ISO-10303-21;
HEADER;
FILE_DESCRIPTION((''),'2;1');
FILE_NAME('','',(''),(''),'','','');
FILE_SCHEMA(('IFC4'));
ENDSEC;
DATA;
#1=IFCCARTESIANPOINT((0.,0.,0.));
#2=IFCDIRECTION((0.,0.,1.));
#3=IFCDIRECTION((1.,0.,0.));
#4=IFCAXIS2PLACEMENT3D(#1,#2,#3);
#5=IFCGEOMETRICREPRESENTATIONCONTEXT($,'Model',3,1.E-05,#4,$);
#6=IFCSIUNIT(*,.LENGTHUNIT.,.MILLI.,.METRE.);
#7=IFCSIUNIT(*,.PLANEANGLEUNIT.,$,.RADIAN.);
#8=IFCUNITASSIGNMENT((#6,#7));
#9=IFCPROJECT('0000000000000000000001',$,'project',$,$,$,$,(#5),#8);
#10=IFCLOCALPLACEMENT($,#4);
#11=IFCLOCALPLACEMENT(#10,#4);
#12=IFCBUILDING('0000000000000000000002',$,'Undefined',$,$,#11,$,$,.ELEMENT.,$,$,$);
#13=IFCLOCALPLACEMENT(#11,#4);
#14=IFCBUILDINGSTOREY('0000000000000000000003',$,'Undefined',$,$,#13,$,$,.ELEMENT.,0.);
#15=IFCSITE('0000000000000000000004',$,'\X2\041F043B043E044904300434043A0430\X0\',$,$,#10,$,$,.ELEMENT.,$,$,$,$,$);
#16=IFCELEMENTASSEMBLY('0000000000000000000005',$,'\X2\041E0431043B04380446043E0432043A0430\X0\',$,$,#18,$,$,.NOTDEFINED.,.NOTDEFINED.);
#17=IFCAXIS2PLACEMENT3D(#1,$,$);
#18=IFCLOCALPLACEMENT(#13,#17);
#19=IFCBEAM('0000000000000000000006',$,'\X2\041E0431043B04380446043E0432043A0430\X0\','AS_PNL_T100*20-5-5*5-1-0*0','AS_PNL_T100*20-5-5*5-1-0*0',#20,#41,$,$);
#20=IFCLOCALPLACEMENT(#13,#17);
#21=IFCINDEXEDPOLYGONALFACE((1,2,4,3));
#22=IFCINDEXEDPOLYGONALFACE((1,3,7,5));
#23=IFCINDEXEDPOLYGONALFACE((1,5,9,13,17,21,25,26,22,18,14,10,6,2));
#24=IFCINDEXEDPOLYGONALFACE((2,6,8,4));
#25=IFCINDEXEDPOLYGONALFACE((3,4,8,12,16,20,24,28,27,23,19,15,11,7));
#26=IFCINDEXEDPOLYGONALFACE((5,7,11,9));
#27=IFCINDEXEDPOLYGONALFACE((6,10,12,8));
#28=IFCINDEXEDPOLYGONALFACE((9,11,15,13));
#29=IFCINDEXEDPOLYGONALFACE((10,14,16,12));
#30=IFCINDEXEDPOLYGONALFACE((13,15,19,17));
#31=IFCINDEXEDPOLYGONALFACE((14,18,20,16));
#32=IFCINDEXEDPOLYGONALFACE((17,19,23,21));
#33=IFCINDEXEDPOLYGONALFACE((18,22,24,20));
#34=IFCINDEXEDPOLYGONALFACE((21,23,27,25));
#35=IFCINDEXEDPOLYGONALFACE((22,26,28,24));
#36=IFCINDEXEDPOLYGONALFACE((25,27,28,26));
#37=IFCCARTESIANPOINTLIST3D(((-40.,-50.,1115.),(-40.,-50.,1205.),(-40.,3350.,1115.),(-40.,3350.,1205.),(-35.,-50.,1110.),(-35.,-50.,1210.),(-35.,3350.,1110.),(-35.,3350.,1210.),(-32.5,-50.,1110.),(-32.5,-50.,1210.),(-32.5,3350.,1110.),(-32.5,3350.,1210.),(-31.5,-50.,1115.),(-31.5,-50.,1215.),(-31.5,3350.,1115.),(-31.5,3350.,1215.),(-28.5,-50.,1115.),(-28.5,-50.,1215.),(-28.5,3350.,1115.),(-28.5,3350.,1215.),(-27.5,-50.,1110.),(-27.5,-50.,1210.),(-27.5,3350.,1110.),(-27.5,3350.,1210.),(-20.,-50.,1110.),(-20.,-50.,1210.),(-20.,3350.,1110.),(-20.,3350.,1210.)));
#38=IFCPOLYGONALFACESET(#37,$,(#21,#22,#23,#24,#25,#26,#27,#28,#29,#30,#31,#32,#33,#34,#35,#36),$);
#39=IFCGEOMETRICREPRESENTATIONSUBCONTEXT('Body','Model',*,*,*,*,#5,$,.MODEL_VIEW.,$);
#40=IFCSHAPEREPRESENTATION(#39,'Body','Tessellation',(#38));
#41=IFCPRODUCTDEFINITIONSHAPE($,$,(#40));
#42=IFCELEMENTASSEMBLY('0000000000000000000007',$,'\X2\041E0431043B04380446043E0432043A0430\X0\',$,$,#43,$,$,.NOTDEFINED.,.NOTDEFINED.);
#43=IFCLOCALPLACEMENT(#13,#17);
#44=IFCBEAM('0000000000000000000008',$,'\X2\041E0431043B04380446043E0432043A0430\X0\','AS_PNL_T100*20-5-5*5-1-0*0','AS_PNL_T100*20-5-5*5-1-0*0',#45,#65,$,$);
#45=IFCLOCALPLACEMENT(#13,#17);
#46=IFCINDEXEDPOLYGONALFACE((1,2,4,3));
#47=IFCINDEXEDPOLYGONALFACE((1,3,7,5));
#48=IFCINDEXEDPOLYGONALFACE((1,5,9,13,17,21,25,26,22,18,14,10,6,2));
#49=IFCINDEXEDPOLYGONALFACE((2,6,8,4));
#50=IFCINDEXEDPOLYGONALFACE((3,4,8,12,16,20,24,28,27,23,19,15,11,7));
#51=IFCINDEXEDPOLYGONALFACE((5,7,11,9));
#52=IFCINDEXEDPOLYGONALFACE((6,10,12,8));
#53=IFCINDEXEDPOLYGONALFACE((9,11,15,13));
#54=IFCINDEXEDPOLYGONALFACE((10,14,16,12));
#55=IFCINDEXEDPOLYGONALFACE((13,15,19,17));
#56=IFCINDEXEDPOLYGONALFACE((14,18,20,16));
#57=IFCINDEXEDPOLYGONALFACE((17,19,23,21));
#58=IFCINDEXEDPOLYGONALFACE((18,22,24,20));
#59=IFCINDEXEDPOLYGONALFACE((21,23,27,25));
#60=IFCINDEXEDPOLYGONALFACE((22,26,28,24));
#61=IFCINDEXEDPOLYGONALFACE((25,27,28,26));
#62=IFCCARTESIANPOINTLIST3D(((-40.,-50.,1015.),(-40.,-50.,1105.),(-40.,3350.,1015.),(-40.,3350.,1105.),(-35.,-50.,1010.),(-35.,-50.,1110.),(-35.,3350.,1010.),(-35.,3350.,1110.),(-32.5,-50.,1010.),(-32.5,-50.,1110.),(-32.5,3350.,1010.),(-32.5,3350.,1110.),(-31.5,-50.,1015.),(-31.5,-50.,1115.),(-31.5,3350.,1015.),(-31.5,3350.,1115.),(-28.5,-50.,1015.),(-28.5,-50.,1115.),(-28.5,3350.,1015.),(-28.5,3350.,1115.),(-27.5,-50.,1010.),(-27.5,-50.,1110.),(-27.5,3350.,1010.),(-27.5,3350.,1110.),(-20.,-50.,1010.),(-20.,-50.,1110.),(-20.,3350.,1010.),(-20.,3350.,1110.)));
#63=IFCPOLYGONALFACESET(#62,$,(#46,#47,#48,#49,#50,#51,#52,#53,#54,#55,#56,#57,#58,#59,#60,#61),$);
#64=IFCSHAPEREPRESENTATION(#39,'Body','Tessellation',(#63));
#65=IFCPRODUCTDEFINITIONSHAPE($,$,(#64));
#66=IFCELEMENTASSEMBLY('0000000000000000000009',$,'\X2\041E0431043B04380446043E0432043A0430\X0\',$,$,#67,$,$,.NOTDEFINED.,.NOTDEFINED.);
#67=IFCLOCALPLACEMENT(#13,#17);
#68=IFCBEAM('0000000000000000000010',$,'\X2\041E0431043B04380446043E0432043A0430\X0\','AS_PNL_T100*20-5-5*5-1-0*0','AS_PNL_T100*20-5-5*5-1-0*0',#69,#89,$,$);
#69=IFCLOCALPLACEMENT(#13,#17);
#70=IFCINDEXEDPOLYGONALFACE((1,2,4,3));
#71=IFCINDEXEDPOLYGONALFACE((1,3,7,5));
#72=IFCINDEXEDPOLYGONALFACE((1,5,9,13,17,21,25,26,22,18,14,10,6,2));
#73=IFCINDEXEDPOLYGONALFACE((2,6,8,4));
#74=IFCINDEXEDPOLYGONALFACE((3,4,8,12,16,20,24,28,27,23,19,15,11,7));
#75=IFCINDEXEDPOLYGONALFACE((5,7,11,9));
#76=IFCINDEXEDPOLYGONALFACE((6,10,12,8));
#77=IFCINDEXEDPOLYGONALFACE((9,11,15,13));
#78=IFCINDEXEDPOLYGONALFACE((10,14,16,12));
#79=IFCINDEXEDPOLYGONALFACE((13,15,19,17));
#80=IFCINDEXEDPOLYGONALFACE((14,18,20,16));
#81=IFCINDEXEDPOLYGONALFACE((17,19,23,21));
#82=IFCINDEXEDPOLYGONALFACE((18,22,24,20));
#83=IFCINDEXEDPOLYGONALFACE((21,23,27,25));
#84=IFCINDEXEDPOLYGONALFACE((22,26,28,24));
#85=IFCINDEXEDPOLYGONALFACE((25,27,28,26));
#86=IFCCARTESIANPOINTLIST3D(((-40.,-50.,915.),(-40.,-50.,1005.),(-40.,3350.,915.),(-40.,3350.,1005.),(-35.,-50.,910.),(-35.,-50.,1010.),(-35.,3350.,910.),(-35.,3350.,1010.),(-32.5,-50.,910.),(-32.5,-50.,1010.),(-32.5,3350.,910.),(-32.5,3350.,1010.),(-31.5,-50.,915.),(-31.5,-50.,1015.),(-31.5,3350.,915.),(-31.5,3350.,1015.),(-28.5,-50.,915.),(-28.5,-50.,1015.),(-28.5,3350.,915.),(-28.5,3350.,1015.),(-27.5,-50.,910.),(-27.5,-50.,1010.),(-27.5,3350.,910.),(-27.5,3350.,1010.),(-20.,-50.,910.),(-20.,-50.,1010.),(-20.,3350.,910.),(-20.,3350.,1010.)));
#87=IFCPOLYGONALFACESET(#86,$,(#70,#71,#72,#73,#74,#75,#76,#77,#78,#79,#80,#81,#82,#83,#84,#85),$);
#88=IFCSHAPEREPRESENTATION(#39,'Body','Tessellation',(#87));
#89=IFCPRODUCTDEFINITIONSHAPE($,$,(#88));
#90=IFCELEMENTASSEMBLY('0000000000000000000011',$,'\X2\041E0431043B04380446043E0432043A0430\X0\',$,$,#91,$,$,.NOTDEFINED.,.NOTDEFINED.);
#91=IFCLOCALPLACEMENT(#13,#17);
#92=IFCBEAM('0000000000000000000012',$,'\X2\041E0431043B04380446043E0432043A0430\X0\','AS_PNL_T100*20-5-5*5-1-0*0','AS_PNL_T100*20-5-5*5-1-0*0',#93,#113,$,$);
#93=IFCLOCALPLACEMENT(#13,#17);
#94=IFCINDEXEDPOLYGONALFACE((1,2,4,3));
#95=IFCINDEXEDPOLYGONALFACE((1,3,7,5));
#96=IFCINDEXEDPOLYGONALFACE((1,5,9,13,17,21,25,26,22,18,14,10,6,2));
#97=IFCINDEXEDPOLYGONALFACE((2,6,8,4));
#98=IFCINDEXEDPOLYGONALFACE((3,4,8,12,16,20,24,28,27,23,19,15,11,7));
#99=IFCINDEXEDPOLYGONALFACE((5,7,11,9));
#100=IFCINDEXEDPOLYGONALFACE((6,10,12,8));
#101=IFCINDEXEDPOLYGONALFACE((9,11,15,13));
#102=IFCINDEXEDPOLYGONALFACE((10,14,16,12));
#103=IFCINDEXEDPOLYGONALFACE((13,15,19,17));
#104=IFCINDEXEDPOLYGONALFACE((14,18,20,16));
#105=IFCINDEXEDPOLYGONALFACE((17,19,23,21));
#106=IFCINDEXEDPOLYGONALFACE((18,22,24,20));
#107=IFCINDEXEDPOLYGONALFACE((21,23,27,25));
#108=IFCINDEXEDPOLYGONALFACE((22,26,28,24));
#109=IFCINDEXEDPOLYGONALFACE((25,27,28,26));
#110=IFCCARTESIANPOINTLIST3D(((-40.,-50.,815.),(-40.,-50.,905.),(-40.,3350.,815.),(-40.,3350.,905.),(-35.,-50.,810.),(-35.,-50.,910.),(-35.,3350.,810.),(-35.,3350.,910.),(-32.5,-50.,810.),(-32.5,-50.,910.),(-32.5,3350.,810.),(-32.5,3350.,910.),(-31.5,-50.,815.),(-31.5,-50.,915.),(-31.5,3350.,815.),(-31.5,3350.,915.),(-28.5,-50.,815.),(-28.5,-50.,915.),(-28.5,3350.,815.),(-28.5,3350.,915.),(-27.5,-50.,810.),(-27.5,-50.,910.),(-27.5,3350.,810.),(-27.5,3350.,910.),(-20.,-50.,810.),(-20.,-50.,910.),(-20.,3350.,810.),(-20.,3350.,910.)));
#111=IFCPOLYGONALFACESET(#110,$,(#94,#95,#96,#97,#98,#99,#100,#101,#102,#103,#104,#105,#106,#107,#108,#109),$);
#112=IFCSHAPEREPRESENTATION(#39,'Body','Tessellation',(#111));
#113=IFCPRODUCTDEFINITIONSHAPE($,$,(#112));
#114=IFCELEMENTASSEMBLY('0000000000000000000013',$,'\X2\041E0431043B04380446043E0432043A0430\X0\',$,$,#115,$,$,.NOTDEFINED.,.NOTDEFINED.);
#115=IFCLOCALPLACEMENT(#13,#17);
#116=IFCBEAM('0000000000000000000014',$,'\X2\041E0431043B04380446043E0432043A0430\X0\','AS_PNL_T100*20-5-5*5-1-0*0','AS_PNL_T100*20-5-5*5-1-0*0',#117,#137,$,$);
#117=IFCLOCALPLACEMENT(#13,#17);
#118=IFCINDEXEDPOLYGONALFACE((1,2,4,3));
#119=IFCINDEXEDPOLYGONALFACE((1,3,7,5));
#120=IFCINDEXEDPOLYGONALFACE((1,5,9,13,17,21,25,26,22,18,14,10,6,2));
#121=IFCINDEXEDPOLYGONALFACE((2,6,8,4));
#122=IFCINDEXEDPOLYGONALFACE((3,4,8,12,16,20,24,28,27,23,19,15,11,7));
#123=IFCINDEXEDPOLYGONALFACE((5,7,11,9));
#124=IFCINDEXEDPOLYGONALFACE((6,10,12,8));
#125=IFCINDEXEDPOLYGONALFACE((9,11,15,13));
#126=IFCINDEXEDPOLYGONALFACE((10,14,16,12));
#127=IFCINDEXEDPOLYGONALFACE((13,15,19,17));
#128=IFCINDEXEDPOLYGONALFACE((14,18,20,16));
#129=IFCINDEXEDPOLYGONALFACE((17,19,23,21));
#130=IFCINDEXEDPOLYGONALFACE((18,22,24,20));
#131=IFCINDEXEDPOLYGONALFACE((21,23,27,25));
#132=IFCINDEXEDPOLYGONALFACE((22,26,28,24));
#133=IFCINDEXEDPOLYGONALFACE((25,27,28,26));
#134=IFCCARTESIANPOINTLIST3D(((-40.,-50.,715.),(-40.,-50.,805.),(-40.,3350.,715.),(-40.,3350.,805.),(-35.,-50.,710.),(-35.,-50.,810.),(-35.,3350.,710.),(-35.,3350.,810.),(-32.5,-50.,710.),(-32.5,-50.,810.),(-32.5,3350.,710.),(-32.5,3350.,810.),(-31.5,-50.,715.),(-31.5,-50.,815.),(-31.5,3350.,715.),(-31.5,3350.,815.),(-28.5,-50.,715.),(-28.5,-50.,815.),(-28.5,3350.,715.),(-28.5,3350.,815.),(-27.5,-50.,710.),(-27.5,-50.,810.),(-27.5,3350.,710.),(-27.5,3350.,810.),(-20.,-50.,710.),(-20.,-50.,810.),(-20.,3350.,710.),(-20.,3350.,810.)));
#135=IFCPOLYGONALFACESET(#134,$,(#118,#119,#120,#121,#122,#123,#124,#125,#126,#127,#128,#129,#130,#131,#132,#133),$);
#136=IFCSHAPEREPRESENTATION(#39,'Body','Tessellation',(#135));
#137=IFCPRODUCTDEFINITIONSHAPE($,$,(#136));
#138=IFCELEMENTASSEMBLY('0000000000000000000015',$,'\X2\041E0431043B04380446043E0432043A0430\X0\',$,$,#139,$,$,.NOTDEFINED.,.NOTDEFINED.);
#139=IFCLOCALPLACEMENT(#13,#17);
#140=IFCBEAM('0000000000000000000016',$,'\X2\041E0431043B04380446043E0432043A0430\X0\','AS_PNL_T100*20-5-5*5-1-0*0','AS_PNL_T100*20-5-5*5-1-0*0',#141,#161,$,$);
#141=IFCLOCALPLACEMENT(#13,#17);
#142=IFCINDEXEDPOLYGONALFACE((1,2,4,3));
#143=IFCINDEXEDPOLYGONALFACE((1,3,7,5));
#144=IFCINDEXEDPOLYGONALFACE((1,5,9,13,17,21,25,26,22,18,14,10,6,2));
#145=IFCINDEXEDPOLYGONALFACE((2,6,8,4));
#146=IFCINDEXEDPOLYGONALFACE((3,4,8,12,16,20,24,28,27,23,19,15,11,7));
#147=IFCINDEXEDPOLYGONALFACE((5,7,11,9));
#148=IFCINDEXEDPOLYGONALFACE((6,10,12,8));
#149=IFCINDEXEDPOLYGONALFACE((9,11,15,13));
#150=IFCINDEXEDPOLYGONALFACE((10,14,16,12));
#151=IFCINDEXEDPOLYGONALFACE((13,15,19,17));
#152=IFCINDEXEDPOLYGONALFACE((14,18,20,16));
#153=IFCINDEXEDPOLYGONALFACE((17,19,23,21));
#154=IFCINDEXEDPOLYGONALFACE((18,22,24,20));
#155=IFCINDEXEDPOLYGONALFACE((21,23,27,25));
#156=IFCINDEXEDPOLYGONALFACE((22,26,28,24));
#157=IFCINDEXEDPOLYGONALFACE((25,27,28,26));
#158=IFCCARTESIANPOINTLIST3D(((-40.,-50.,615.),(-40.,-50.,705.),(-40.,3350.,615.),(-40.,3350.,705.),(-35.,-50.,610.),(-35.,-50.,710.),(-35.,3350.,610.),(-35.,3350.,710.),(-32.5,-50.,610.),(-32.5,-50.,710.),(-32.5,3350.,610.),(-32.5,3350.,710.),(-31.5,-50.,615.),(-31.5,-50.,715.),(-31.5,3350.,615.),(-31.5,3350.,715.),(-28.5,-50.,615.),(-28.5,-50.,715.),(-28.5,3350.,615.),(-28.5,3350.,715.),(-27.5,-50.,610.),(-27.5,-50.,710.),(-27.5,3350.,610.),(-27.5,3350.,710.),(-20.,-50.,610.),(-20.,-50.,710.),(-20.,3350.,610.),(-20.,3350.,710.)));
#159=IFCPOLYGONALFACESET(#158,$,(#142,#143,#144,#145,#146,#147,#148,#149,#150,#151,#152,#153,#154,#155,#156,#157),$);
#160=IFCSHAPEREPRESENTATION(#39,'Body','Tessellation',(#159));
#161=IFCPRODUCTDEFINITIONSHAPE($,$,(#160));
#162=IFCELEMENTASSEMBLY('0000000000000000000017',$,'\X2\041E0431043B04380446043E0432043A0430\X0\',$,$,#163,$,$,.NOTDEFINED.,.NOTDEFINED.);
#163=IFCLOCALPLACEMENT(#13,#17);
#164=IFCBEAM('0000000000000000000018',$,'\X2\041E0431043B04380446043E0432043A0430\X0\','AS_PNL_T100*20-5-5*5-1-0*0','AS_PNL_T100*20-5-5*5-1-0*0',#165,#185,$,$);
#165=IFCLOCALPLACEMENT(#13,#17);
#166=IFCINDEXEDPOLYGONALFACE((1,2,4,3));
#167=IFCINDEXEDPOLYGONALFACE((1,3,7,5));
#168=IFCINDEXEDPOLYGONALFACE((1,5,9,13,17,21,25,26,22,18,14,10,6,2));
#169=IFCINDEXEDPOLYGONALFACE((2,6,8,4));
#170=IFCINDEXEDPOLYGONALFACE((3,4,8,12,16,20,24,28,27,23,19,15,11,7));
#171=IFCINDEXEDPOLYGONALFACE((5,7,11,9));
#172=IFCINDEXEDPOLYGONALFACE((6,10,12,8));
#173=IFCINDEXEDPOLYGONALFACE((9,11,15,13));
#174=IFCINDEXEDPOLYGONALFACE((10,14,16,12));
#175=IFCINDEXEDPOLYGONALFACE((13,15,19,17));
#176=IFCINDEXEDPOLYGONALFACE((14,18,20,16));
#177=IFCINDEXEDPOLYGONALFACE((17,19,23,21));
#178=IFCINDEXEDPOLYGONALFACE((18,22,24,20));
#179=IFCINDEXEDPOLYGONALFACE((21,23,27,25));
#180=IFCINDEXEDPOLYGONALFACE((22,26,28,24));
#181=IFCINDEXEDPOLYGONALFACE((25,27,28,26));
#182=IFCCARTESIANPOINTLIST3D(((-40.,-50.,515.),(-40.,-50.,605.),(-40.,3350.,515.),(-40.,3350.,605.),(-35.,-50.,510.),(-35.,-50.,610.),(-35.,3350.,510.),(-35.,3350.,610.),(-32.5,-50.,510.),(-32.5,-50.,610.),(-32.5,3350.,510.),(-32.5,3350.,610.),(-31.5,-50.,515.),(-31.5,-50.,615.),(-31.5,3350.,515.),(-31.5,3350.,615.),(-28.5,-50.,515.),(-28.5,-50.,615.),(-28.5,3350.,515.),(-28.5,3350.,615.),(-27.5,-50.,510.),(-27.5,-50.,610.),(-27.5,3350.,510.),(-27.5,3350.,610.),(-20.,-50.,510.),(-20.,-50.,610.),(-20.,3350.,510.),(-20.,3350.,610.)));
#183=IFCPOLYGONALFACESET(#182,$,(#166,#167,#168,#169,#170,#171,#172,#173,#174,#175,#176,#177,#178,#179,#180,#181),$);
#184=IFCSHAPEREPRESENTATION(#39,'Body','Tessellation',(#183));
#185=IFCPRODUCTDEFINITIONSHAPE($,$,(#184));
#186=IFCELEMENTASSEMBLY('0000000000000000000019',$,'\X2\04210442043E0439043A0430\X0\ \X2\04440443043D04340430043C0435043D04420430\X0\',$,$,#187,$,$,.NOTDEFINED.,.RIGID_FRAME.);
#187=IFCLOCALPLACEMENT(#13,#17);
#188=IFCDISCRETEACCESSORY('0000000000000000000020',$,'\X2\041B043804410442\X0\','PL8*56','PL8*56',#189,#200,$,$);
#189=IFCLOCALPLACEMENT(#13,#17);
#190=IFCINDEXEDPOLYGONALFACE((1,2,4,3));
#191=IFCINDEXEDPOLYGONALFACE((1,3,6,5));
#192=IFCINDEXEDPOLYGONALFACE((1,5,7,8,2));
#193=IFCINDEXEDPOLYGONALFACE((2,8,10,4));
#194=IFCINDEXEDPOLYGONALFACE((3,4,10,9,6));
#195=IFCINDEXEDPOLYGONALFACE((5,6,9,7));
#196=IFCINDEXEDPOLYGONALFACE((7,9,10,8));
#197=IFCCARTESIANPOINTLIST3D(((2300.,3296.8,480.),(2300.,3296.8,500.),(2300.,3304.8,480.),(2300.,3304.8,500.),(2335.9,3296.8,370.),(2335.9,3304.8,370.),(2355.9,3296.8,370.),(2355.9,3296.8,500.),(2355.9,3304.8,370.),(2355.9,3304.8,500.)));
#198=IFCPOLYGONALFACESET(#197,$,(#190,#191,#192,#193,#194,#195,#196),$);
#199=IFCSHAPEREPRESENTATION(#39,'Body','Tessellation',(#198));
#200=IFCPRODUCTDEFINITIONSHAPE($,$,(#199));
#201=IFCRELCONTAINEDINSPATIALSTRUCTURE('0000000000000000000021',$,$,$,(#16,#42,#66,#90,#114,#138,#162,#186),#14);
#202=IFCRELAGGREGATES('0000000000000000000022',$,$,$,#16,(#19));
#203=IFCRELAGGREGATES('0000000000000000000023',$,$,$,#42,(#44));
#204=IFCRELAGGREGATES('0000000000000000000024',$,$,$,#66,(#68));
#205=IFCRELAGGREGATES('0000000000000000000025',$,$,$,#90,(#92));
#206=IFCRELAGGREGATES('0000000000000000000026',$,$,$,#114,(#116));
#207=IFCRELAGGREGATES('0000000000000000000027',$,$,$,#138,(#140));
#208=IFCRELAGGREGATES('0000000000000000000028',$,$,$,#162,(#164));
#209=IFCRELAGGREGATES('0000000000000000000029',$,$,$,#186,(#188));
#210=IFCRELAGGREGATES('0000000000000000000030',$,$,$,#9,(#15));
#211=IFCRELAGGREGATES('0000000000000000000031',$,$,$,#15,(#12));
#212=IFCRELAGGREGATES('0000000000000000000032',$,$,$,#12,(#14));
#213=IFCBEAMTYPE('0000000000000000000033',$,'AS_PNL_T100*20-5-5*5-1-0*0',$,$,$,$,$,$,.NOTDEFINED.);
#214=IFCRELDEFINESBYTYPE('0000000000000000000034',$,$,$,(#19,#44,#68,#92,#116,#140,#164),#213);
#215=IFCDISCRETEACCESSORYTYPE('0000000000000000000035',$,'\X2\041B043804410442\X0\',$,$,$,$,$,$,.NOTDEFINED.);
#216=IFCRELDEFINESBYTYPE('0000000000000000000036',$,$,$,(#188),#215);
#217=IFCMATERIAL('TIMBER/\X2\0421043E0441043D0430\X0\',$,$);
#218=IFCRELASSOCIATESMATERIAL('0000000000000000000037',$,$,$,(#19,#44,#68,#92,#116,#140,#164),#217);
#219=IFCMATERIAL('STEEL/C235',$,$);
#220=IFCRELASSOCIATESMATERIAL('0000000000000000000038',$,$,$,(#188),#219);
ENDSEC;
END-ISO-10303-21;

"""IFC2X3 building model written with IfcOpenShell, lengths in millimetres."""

from ifc_helpers import new_model, si_unit, frame, origin_with_axes, place, context, subcontext, project, spatial, polyline, outline, extrude, material, type_object, element, aggregate, save


model = new_model("IFC2X3")

# Units and contexts
model_context = context("Model", 3, precision=1e-05, world=origin_with_axes())
body_context = subcontext(model_context, "Body", "Model", "MODEL_VIEW")
ifc_project = project(units=[si_unit("LENGTHUNIT", "METRE", prefix="MILLI"), si_unit("PLANEANGLEUNIT", "RADIAN")], contexts=[model_context])

# Site, building, storey
site_placement = place(None, origin_with_axes())
site = spatial("IfcSite", under=ifc_project, at=site_placement, Name="Площадка", CompositionType="ELEMENT")
building_placement = place(site_placement, origin_with_axes())
building = spatial("IfcBuilding", under=site, at=building_placement, Name="Undefined", CompositionType="ELEMENT")
storey_placement = place(building_placement, origin_with_axes())
storey = spatial("IfcBuildingStorey", under=building, at=storey_placement, Name="Undefined", CompositionType="ELEMENT", Elevation=0.0)

# Shared definitions
ifc_material_1 = material(Name="STEEL/C235")

# Element assemblies, beams
ifc_material_2 = material(Name="TIMBER/Сосна")
beam_type = type_object("IfcBeamType", Name="AS_PNL_T100*20-5-5*5-1-0*0", PredefinedType="NOTDEFINED")
assembly_1_placement = place(storey_placement, origin_with_axes())
assembly_1 = element("IfcElementAssembly", 1, at=assembly_1_placement, inside=storey, Name="Облицовка", AssemblyPlace="NOTDEFINED", PredefinedType="NOTDEFINED")
beam_1_placement = place(assembly_1_placement, frame((-30.0, 3350.0, 1160.0), z_axis=(0.0, 0.0, 1.0), x_axis=(0.0, -1.0, 0.0)))
beam_1 = element("IfcBeam", 2, at=beam_1_placement, type_object=beam_type, material=ifc_material_2, Name="Облицовка", Description="AS_PNL_T100*20-5-5*5-1-0*0", ObjectType="AS_PNL_T100*20-5-5*5-1-0*0", context=body_context, shape_type="SweptSolid", body=[
    extrude(outline(polyline([(-2.5, -50.0), (-10.0, -50.0), (-10.0, 50.0), (-2.5, 50.0), (-1.5, 55.0), (1.5, 55.0), (2.5, 50.0), (5.0, 50.0), (10.0, 45.0), (10.0, -45.0), (5.0, -50.0), (2.5, -50.0), (1.5, -45.0), (-1.5, -45.0), (-2.5, -50.0)])), frame((3400.0, 0.0, 0.0), z_axis=(-1.0, 0.0, 0.0), x_axis=(0.0, -1.0, 0.0)), (0.0, 0.0, 1.0), 3400.0),
])
aggregate(assembly_1, [beam_1])
assembly_2_placement = place(storey_placement, origin_with_axes())
assembly_2 = element("IfcElementAssembly", 3, at=assembly_2_placement, inside=storey, Name="Облицовка", AssemblyPlace="NOTDEFINED", PredefinedType="NOTDEFINED")
beam_2_placement = place(assembly_2_placement, frame((-30.0, 3350.0, 1060.0), z_axis=(0.0, 0.0, 1.0), x_axis=(0.0, -1.0, 0.0)))
beam_2 = element("IfcBeam", 4, at=beam_2_placement, type_object=beam_type, material=ifc_material_2, Name="Облицовка", Description="AS_PNL_T100*20-5-5*5-1-0*0", ObjectType="AS_PNL_T100*20-5-5*5-1-0*0", context=body_context, shape_type="SweptSolid", body=[
    extrude(outline(polyline([(-2.5, -50.0), (-10.0, -50.0), (-10.0, 50.0), (-2.5, 50.0), (-1.5, 55.0), (1.5, 55.0), (2.5, 50.0), (5.0, 50.0), (10.0, 45.0), (10.0, -45.0), (5.0, -50.0), (2.5, -50.0), (1.5, -45.0), (-1.5, -45.0), (-2.5, -50.0)])), frame((3400.0, 0.0, 0.0), z_axis=(-1.0, 0.0, 0.0), x_axis=(0.0, -1.0, 0.0)), (0.0, 0.0, 1.0), 3400.0),
])
aggregate(assembly_2, [beam_2])
assembly_3_placement = place(storey_placement, origin_with_axes())
assembly_3 = element("IfcElementAssembly", 5, at=assembly_3_placement, inside=storey, Name="Облицовка", AssemblyPlace="NOTDEFINED", PredefinedType="NOTDEFINED")
beam_3_placement = place(assembly_3_placement, frame((-30.0, 3350.0, 960.0), z_axis=(0.0, 0.0, 1.0), x_axis=(0.0, -1.0, 0.0)))
beam_3 = element("IfcBeam", 6, at=beam_3_placement, type_object=beam_type, material=ifc_material_2, Name="Облицовка", Description="AS_PNL_T100*20-5-5*5-1-0*0", ObjectType="AS_PNL_T100*20-5-5*5-1-0*0", context=body_context, shape_type="SweptSolid", body=[
    extrude(outline(polyline([(-2.5, -50.0), (-10.0, -50.0), (-10.0, 50.0), (-2.5, 50.0), (-1.5, 55.0), (1.5, 55.0), (2.5, 50.0), (5.0, 50.0), (10.0, 45.0), (10.0, -45.0), (5.0, -50.0), (2.5, -50.0), (1.5, -45.0), (-1.5, -45.0), (-2.5, -50.0)])), frame((3400.0, 0.0, 0.0), z_axis=(-1.0, 0.0, 0.0), x_axis=(0.0, -1.0, 0.0)), (0.0, 0.0, 1.0), 3400.0),
])
aggregate(assembly_3, [beam_3])
assembly_4_placement = place(storey_placement, origin_with_axes())
assembly_4 = element("IfcElementAssembly", 7, at=assembly_4_placement, inside=storey, Name="Облицовка", AssemblyPlace="NOTDEFINED", PredefinedType="NOTDEFINED")
beam_4_placement = place(assembly_4_placement, frame((-30.0, 3350.0, 860.0), z_axis=(0.0, 0.0, 1.0), x_axis=(0.0, -1.0, 0.0)))
beam_4 = element("IfcBeam", 8, at=beam_4_placement, type_object=beam_type, material=ifc_material_2, Name="Облицовка", Description="AS_PNL_T100*20-5-5*5-1-0*0", ObjectType="AS_PNL_T100*20-5-5*5-1-0*0", context=body_context, shape_type="SweptSolid", body=[
    extrude(outline(polyline([(-2.5, -50.0), (-10.0, -50.0), (-10.0, 50.0), (-2.5, 50.0), (-1.5, 55.0), (1.5, 55.0), (2.5, 50.0), (5.0, 50.0), (10.0, 45.0), (10.0, -45.0), (5.0, -50.0), (2.5, -50.0), (1.5, -45.0), (-1.5, -45.0), (-2.5, -50.0)])), frame((3400.0, 0.0, 0.0), z_axis=(-1.0, 0.0, 0.0), x_axis=(0.0, -1.0, 0.0)), (0.0, 0.0, 1.0), 3400.0),
])
aggregate(assembly_4, [beam_4])
assembly_5_placement = place(storey_placement, origin_with_axes())
assembly_5 = element("IfcElementAssembly", 9, at=assembly_5_placement, inside=storey, Name="Облицовка", AssemblyPlace="NOTDEFINED", PredefinedType="NOTDEFINED")
beam_5_placement = place(assembly_5_placement, frame((-30.0, 3350.0, 760.0), z_axis=(0.0, 0.0, 1.0), x_axis=(0.0, -1.0, 0.0)))
beam_5 = element("IfcBeam", 10, at=beam_5_placement, type_object=beam_type, material=ifc_material_2, Name="Облицовка", Description="AS_PNL_T100*20-5-5*5-1-0*0", ObjectType="AS_PNL_T100*20-5-5*5-1-0*0", context=body_context, shape_type="SweptSolid", body=[
    extrude(outline(polyline([(-2.5, -50.0), (-10.0, -50.0), (-10.0, 50.0), (-2.5, 50.0), (-1.5, 55.0), (1.5, 55.0), (2.5, 50.0), (5.0, 50.0), (10.0, 45.0), (10.0, -45.0), (5.0, -50.0), (2.5, -50.0), (1.5, -45.0), (-1.5, -45.0), (-2.5, -50.0)])), frame((3400.0, 0.0, 0.0), z_axis=(-1.0, 0.0, 0.0), x_axis=(0.0, -1.0, 0.0)), (0.0, 0.0, 1.0), 3400.0),
])
aggregate(assembly_5, [beam_5])
assembly_6_placement = place(storey_placement, origin_with_axes())
assembly_6 = element("IfcElementAssembly", 11, at=assembly_6_placement, inside=storey, Name="Облицовка", AssemblyPlace="NOTDEFINED", PredefinedType="NOTDEFINED")
beam_6_placement = place(assembly_6_placement, frame((-30.0, 3350.0, 660.0), z_axis=(0.0, 0.0, 1.0), x_axis=(0.0, -1.0, 0.0)))
beam_6 = element("IfcBeam", 12, at=beam_6_placement, type_object=beam_type, material=ifc_material_2, Name="Облицовка", Description="AS_PNL_T100*20-5-5*5-1-0*0", ObjectType="AS_PNL_T100*20-5-5*5-1-0*0", context=body_context, shape_type="SweptSolid", body=[
    extrude(outline(polyline([(-2.5, -50.0), (-10.0, -50.0), (-10.0, 50.0), (-2.5, 50.0), (-1.5, 55.0), (1.5, 55.0), (2.5, 50.0), (5.0, 50.0), (10.0, 45.0), (10.0, -45.0), (5.0, -50.0), (2.5, -50.0), (1.5, -45.0), (-1.5, -45.0), (-2.5, -50.0)])), frame((3400.0, 0.0, 0.0), z_axis=(-1.0, 0.0, 0.0), x_axis=(0.0, -1.0, 0.0)), (0.0, 0.0, 1.0), 3400.0),
])
aggregate(assembly_6, [beam_6])
assembly_7_placement = place(storey_placement, origin_with_axes())
assembly_7 = element("IfcElementAssembly", 13, at=assembly_7_placement, inside=storey, Name="Облицовка", AssemblyPlace="NOTDEFINED", PredefinedType="NOTDEFINED")
beam_7_placement = place(assembly_7_placement, frame((-30.0, 3350.0, 560.0), z_axis=(0.0, 0.0, 1.0), x_axis=(0.0, -1.0, 0.0)))
beam_7 = element("IfcBeam", 14, at=beam_7_placement, type_object=beam_type, material=ifc_material_2, Name="Облицовка", Description="AS_PNL_T100*20-5-5*5-1-0*0", ObjectType="AS_PNL_T100*20-5-5*5-1-0*0", context=body_context, shape_type="SweptSolid", body=[
    extrude(outline(polyline([(-2.5, -50.0), (-10.0, -50.0), (-10.0, 50.0), (-2.5, 50.0), (-1.5, 55.0), (1.5, 55.0), (2.5, 50.0), (5.0, 50.0), (10.0, 45.0), (10.0, -45.0), (5.0, -50.0), (2.5, -50.0), (1.5, -45.0), (-1.5, -45.0), (-2.5, -50.0)])), frame((3400.0, 0.0, 0.0), z_axis=(-1.0, 0.0, 0.0), x_axis=(0.0, -1.0, 0.0)), (0.0, 0.0, 1.0), 3400.0),
])
aggregate(assembly_7, [beam_7])

# Element assembly, discrete accessory
assembly_8_placement = place(storey_placement, origin_with_axes())
assembly_8 = element("IfcElementAssembly", 15, at=assembly_8_placement, inside=storey, Name="Стойка фундамента", AssemblyPlace="NOTDEFINED", PredefinedType="RIGID_FRAME")
discrete_accessory_type = type_object("IfcDiscreteAccessoryType", Name="Лист")
discrete_accessory_1_placement = place(assembly_8_placement, frame((2355.9, 3300.8, 500.0), z_axis=(0.0, -1.0, 0.0), x_axis=(-1.0, 0.0, 0.0)))
discrete_accessory_1 = element("IfcDiscreteAccessory", 16, at=discrete_accessory_1_placement, type_object=discrete_accessory_type, material=ifc_material_1, Name="Лист", Description="PL8*56", ObjectType="PL8*56", context=body_context, shape_type="SweptSolid", body=[
    extrude(outline(polyline([(0.0, 0.0), (55.9, 0.0), (55.9, 20.0), (20.0, 130.0), (0.0, 130.0), (0.0, 0.0)])), frame((0.0, 0.0, -4.0), z_axis=(0.0, 0.0, 1.0), x_axis=(1.0, 0.0, 0.0)), (0.0, 0.0, 1.0), 8.0),
])
aggregate(assembly_8, [discrete_accessory_1])

save(model, "model.ifc")
